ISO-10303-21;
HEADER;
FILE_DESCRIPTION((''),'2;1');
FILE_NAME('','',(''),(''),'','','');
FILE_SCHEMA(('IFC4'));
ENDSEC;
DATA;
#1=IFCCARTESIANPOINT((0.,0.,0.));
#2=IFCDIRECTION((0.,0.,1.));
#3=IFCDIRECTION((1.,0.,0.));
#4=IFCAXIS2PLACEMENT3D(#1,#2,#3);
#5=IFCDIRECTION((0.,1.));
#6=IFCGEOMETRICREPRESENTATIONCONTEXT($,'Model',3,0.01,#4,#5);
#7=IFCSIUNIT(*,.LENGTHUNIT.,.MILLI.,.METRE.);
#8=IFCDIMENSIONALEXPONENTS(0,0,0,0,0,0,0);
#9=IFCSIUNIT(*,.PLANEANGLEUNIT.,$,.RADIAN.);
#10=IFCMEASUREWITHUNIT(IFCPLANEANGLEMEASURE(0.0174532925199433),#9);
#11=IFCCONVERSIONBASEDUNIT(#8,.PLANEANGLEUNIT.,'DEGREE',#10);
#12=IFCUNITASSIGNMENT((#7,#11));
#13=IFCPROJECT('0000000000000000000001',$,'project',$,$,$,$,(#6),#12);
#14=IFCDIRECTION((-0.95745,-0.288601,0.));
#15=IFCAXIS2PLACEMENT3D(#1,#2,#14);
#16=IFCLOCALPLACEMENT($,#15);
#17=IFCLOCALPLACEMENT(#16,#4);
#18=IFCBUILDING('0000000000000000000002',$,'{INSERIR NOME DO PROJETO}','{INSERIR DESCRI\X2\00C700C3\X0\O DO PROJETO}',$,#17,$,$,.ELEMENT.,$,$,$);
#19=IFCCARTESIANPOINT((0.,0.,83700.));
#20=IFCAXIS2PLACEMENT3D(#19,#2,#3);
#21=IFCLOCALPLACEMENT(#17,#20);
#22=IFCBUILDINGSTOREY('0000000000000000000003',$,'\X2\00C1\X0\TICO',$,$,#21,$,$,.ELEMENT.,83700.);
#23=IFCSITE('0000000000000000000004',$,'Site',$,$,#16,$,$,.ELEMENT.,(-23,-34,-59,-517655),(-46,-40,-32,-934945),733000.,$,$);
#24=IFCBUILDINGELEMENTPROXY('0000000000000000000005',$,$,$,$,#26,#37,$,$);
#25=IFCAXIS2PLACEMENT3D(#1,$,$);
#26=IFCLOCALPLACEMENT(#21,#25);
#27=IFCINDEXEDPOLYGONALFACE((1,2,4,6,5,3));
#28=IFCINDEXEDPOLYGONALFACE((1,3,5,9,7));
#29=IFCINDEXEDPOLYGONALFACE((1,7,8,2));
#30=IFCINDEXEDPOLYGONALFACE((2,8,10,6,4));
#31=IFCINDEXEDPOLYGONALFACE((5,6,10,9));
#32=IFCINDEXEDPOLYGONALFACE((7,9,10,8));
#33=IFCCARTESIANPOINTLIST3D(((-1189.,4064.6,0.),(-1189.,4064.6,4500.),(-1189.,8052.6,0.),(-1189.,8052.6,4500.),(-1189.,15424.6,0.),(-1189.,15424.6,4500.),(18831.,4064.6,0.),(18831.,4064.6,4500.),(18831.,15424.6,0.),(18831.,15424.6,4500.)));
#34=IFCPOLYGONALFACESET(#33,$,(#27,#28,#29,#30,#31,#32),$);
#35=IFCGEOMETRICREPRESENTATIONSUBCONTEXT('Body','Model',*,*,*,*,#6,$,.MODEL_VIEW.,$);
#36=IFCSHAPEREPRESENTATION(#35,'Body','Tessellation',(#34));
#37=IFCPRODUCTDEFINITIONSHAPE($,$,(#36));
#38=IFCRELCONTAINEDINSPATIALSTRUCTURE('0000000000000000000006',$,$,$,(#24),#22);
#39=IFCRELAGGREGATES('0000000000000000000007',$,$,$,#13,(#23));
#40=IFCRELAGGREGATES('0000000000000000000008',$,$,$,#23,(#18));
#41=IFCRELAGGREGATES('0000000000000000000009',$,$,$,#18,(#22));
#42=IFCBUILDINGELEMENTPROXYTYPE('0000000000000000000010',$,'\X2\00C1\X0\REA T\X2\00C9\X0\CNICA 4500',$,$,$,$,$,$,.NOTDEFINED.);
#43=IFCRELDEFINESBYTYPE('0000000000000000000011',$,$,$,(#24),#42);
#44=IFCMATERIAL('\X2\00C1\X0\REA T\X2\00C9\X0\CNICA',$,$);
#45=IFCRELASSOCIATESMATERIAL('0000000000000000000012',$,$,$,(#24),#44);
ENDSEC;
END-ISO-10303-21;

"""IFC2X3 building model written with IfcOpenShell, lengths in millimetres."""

from ifc_helpers import new_model, entity, si_unit, converted_unit, direction, frame, origin_with_axes, place, context, subcontext, project, spatial, polyline, outline, extrude, material, type_object, element, save


model = new_model("IFC2X3")

# Units and contexts
model_context = context("Model", 3, precision=0.01, world=origin_with_axes(), true_north=direction((0.0, 1.0)))
body_context = subcontext(model_context, "Body", "Model", "MODEL_VIEW")
ifc_project = project(units=[si_unit("LENGTHUNIT", "METRE", prefix="MILLI"), converted_unit("PLANEANGLEUNIT", "DEGREE", entity("IfcPlaneAngleMeasure", 0.0174532925199433), si_unit("PLANEANGLEUNIT", "RADIAN"), dimensions=[0, 0, 0, 0, 0, 0, 0])], contexts=[model_context])

# Site, building, storey
site_placement = place(None, frame((0.0, 0.0, 0.0), z_axis=(0.0, 0.0, 1.0), x_axis=(-0.95745, -0.288601, 0.0)))
site = spatial("IfcSite", under=ifc_project, at=site_placement, Name="Site", CompositionType="ELEMENT", RefLatitude=(-23, -34, -59, -517655), RefLongitude=(-46, -40, -32, -934945), RefElevation=733000.0)
building_placement = place(site_placement, origin_with_axes())
building = spatial("IfcBuilding", under=site, at=building_placement, Name="{INSERIR NOME DO PROJETO}", Description="{INSERIR DESCRIÇÃO DO PROJETO}", CompositionType="ELEMENT")
storey_placement = place(building_placement, frame((0.0, 0.0, 83700.0), z_axis=(0.0, 0.0, 1.0), x_axis=(1.0, 0.0, 0.0)))
storey = spatial("IfcBuildingStorey", under=building, at=storey_placement, Name="ÁTICO", CompositionType="ELEMENT", Elevation=83700.0)

# Building element proxy
ifc_material = material(Name="ÁREA TÉCNICA")
building_element_proxy_type = type_object("IfcBuildingElementProxyType", Name="ÁREA TÉCNICA 4500", PredefinedType="NOTDEFINED")
proxy_placement = place(storey_placement, frame((-1189.0, 8052.6, 0.0), z_axis=(0.0, 0.0, 1.0), x_axis=(1.0, 0.0, 0.0)))
element("IfcBuildingElementProxy", 1, at=proxy_placement, inside=storey, type_object=building_element_proxy_type, material=ifc_material, context=body_context, shape_type="SweptSolid", body=[
    extrude(outline(polyline([(0.0, 0.0), (0.0, -3988.0), (20020.0, -3988.0), (20020.0, 7372.0), (0.0, 7372.0), (0.0, 0.0)])), origin_with_axes(), (0.0, 0.0, 1.0), 4500.0),
])

save(model, "model.ifc")
